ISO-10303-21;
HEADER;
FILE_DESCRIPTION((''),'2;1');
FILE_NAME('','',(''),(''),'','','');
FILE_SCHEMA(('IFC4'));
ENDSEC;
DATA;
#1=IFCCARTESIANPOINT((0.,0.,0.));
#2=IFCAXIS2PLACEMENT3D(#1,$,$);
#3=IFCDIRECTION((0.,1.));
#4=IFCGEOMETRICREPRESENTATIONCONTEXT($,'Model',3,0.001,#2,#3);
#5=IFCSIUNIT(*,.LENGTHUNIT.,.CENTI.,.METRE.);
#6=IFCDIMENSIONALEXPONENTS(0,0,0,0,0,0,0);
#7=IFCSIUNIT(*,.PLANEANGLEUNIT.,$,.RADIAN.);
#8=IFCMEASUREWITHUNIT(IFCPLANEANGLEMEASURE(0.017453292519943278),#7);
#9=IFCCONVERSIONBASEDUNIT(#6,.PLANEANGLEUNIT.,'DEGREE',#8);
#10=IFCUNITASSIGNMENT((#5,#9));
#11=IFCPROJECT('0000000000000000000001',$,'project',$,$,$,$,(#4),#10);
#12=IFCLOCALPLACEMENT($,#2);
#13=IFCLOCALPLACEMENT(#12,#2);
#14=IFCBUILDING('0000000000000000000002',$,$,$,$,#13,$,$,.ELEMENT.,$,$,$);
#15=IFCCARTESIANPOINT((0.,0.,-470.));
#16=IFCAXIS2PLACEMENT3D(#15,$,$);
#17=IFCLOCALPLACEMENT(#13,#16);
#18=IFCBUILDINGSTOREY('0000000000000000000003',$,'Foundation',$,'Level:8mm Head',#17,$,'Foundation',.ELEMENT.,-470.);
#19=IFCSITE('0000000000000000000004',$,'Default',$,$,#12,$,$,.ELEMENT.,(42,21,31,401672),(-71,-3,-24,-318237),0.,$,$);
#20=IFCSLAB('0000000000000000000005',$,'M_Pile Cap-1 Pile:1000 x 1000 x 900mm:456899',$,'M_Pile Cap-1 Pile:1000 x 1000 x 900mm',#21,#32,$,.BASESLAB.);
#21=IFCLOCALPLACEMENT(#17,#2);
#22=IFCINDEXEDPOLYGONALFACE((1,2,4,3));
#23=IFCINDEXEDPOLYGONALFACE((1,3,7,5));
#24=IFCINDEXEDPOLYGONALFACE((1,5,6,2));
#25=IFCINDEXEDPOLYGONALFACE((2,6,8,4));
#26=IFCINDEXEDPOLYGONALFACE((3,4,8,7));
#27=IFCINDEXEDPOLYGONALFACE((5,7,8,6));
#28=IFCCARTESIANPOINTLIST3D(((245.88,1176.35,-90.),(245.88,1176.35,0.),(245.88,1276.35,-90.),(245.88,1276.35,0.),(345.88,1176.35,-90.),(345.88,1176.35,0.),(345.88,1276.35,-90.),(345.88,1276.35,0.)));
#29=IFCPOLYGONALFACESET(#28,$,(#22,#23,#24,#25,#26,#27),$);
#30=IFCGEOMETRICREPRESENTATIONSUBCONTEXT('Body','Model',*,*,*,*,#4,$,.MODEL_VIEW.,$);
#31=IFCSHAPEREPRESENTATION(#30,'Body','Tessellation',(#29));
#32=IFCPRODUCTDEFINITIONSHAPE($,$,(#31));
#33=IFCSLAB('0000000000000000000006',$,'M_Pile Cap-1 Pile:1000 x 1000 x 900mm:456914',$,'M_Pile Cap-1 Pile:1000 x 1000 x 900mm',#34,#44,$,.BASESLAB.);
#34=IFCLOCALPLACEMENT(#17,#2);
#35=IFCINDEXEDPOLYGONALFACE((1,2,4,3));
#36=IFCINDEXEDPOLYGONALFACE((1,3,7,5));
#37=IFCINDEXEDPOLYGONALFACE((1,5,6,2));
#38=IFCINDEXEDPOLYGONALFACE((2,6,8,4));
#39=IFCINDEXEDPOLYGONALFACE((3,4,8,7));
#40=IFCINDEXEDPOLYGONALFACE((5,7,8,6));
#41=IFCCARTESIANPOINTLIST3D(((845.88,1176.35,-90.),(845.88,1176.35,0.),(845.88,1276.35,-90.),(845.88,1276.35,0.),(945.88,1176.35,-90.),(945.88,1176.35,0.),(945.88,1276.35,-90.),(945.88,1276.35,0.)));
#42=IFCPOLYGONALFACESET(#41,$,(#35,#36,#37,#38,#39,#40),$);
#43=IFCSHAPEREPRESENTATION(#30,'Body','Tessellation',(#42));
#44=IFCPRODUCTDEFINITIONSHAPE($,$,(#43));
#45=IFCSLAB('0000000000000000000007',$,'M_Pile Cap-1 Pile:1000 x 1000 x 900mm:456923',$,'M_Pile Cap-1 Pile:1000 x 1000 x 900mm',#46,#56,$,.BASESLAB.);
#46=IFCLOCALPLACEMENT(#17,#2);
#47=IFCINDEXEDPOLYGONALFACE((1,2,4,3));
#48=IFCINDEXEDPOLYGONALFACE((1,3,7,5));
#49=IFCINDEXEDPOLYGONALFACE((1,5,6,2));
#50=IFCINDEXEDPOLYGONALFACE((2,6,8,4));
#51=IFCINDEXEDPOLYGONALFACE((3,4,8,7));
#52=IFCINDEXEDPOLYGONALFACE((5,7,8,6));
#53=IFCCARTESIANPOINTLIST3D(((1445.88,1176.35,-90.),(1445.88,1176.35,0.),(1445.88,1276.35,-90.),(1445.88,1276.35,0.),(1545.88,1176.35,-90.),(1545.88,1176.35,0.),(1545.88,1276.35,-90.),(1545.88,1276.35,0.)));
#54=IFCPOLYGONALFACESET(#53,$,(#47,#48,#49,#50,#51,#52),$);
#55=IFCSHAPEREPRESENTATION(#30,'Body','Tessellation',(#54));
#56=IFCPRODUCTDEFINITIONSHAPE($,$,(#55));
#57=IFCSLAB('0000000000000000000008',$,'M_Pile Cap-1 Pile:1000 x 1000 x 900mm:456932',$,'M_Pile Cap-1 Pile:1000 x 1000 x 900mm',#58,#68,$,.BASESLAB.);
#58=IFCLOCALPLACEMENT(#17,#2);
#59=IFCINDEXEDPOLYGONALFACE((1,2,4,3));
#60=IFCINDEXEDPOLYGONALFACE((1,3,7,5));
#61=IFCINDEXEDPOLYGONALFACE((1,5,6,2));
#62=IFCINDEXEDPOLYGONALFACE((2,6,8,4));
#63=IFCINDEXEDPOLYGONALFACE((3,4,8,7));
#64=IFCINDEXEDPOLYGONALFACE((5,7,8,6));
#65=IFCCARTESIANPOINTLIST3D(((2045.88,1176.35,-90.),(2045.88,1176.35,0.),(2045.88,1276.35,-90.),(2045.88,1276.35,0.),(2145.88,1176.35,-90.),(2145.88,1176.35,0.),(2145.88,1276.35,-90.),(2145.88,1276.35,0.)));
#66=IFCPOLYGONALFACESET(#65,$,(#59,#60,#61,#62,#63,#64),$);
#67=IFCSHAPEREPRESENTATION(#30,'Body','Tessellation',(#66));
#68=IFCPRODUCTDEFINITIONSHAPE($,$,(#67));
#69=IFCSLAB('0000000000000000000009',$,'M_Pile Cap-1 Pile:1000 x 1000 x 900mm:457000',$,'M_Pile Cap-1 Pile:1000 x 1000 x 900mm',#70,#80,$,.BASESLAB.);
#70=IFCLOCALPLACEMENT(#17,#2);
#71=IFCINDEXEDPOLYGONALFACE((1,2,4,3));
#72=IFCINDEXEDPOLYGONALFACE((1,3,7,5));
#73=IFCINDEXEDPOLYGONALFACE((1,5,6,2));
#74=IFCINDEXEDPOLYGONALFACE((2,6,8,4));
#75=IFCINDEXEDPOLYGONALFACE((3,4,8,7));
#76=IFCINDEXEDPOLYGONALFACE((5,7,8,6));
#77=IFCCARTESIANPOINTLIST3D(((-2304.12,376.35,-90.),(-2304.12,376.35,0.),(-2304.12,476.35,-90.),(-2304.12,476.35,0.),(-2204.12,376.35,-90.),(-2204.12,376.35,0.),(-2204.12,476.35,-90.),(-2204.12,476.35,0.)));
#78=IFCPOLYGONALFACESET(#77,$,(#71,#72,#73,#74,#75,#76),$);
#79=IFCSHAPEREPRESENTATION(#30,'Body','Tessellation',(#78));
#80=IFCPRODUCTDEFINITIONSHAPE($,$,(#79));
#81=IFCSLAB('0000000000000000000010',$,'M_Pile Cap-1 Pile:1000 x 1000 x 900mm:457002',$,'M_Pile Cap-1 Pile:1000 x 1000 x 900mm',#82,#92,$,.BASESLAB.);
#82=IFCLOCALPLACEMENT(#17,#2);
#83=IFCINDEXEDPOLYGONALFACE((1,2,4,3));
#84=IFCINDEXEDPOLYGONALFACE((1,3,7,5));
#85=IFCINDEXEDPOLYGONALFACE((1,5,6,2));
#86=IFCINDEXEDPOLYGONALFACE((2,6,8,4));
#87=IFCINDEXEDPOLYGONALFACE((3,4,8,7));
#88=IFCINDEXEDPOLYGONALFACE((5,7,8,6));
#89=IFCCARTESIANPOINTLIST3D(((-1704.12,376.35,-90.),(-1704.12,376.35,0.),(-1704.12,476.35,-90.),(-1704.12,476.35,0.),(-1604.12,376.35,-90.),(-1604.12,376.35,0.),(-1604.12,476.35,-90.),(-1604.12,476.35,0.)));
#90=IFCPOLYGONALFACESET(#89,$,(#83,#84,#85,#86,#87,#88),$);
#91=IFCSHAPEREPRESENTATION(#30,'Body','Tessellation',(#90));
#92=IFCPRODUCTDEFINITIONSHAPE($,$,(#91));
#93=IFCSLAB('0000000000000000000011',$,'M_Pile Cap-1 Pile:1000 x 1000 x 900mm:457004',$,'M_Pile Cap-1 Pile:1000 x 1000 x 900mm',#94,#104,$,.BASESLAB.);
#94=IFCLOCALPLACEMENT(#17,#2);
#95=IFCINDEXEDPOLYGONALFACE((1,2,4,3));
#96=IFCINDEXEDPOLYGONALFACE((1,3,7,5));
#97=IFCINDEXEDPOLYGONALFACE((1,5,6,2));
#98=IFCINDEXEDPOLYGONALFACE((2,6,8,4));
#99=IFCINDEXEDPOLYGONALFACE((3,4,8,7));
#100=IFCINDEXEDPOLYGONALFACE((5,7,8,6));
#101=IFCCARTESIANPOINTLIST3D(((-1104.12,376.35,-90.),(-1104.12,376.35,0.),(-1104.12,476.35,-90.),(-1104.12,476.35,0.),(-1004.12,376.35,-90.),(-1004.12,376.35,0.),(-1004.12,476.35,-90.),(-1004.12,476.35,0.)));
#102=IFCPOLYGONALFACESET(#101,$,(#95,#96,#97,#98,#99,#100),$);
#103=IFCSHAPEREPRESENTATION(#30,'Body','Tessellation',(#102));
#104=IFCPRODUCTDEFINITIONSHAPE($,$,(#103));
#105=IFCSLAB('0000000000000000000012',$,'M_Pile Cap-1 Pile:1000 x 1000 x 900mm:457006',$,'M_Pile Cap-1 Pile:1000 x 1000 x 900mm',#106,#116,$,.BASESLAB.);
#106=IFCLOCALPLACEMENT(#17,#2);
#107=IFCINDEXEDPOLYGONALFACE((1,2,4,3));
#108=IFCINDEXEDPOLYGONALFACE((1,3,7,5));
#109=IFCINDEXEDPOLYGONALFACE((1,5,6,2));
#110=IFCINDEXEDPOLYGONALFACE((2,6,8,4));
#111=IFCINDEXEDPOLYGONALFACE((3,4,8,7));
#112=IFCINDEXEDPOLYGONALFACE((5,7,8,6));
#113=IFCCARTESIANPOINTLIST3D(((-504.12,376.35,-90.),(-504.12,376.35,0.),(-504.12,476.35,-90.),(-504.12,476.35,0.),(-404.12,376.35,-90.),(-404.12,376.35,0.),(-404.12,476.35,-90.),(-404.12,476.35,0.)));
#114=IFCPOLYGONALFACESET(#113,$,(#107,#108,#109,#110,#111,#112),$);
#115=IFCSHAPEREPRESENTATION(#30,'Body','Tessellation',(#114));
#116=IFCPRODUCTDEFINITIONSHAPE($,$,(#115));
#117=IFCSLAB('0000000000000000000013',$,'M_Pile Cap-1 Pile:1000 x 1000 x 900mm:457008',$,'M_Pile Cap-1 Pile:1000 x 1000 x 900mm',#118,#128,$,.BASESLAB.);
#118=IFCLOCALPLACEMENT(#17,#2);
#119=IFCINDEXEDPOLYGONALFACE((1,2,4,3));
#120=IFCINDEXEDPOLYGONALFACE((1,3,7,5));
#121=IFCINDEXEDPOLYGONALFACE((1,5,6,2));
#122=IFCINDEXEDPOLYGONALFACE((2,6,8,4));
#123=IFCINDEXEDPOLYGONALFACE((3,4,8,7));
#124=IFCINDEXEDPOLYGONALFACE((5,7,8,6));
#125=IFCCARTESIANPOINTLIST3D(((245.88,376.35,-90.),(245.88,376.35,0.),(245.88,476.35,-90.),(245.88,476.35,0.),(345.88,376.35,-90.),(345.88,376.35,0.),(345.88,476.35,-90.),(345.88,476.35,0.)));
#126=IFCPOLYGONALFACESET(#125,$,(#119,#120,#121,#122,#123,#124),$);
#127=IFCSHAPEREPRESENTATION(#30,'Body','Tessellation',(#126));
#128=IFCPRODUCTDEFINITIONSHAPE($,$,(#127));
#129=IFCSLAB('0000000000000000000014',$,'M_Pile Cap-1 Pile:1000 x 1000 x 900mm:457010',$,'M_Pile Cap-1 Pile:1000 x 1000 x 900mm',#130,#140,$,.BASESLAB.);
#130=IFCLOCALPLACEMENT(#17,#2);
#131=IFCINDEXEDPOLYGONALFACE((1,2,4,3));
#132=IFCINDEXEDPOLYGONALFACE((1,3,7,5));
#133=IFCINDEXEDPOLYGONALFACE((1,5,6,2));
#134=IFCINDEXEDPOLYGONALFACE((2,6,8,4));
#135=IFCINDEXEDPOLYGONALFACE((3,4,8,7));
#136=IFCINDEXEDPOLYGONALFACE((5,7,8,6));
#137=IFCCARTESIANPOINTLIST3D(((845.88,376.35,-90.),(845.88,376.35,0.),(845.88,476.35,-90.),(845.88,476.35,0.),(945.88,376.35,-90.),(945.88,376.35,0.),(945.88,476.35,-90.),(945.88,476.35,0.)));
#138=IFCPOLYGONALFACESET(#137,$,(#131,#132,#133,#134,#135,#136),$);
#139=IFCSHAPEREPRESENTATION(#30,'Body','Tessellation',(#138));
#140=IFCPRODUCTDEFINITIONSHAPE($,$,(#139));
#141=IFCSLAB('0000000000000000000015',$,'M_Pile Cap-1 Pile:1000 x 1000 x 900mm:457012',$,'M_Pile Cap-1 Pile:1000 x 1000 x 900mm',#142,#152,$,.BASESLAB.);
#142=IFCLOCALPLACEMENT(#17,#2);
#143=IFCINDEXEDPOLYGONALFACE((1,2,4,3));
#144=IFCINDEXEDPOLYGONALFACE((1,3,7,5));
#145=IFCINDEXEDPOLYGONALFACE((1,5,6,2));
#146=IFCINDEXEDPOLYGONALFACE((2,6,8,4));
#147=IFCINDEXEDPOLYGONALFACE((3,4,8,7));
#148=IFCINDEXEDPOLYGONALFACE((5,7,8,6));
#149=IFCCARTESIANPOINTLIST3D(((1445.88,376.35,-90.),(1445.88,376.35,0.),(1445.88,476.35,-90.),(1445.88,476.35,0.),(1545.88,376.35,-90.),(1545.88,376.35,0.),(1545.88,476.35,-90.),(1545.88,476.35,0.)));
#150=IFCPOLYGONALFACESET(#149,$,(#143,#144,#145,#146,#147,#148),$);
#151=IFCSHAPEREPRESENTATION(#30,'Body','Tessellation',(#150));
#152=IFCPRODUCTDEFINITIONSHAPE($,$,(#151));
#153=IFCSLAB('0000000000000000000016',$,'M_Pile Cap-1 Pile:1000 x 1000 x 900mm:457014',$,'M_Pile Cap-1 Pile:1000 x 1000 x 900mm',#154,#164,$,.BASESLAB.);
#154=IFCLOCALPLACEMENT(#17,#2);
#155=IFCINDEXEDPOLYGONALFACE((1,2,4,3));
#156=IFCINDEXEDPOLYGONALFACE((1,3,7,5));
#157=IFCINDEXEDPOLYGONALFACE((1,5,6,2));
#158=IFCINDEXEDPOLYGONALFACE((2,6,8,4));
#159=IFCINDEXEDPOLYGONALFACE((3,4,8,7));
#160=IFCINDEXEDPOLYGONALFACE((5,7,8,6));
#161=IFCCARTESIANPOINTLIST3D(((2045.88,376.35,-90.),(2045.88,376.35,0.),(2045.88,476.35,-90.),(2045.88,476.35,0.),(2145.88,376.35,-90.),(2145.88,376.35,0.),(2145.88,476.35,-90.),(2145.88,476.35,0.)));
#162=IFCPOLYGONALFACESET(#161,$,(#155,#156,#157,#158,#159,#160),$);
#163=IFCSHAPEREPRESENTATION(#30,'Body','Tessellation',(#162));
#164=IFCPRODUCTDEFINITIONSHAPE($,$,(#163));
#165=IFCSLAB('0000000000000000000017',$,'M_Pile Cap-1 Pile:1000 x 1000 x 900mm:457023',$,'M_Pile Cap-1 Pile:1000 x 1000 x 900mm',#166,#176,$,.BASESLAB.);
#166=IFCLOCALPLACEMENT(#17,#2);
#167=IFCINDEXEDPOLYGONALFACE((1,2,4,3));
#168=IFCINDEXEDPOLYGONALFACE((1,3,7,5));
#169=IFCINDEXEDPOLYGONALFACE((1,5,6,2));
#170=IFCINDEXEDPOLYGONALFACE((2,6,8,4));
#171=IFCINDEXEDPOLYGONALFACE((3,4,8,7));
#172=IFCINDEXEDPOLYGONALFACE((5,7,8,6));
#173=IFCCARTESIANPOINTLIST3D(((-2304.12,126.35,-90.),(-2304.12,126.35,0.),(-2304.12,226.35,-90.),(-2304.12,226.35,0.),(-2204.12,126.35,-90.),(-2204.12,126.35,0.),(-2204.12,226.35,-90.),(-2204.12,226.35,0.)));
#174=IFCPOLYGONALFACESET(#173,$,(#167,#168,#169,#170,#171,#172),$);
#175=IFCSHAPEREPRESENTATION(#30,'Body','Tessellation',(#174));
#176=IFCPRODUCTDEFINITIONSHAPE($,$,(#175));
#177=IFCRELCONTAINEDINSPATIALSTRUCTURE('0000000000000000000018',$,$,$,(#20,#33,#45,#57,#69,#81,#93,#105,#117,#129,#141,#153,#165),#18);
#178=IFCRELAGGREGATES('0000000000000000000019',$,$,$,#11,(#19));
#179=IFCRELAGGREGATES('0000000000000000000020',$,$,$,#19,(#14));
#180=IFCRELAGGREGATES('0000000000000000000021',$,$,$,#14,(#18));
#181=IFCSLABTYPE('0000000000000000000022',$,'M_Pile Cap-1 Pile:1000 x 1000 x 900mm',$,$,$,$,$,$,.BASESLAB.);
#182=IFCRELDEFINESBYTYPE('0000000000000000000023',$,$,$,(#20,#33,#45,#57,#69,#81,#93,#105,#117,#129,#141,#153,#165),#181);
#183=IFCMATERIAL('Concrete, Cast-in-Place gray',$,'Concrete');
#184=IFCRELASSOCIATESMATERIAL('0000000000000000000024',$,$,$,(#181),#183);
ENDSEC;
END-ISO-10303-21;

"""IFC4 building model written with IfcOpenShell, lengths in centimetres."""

from ifc_helpers import new_model, entity, si_unit, converted_unit, direction, frame, origin, place, context, subcontext, project, spatial, indexed_curve, outline, extrude, material, type_object, element, save


model = new_model("IFC4")

# Units and contexts
model_context = context("Model", 3, precision=0.001, world=origin(), true_north=direction((0.0, 1.0)))
body_context = subcontext(model_context, "Body", "Model", "MODEL_VIEW")
ifc_project = project(units=[si_unit("LENGTHUNIT", "METRE", prefix="CENTI"), converted_unit("PLANEANGLEUNIT", "DEGREE", entity("IfcPlaneAngleMeasure", 0.017453292519943278), si_unit("PLANEANGLEUNIT", "RADIAN"), dimensions=[0, 0, 0, 0, 0, 0, 0])], contexts=[model_context])

# Site, building, storey
site_placement = place(None, origin())
site = spatial("IfcSite", under=ifc_project, at=site_placement, Name="Default", CompositionType="ELEMENT", RefLatitude=(42, 21, 31, 401672), RefLongitude=(-71, -3, -24, -318237), RefElevation=0.0)
building_placement = place(site_placement, origin())
building = spatial("IfcBuilding", under=site, at=building_placement, CompositionType="ELEMENT")
storey_placement = place(building_placement, frame((0.0, 0.0, -470.0)))
storey = spatial("IfcBuildingStorey", under=building, at=storey_placement, Name="Foundation", ObjectType="Level:8mm Head", LongName="Foundation", CompositionType="ELEMENT", Elevation=-470.0)

# Slabs
ifc_material_1 = material(Name="Concrete, Cast-in-Place gray", Category="Concrete")
slab_type_1 = type_object("IfcSlabType", Name="M_Pile Cap-1 Pile:1000 x 1000 x 900mm", PredefinedType="BASESLAB", material=ifc_material_1)
slab_1_placement = place(storey_placement, origin())
element("IfcSlab", 1, at=slab_1_placement, inside=storey, type_object=slab_type_1, Name="M_Pile Cap-1 Pile:1000 x 1000 x 900mm:456899", ObjectType="M_Pile Cap-1 Pile:1000 x 1000 x 900mm", PredefinedType="BASESLAB", context=body_context, shape_type="SweptSolid", body=[
    extrude(outline(indexed_curve([(-50.0, -50.0), (50.0, -50.0), (50.0, 50.0), (-50.0, 50.0), (-50.0, -50.0)], self_intersect=False)), frame((295.88, 1226.35, -90.0), z_axis=(0.0, 0.0, 1.0), x_axis=(-1.0, 0.0, 0.0)), (0.0, 0.0, 1.0), 90.0),
])
slab_2_placement = place(storey_placement, origin())
element("IfcSlab", 2, at=slab_2_placement, inside=storey, type_object=slab_type_1, Name="M_Pile Cap-1 Pile:1000 x 1000 x 900mm:456914", ObjectType="M_Pile Cap-1 Pile:1000 x 1000 x 900mm", PredefinedType="BASESLAB", context=body_context, shape_type="SweptSolid", body=[
    extrude(outline(indexed_curve([(-50.0, -50.0), (50.0, -50.0), (50.0, 50.0), (-50.0, 50.0), (-50.0, -50.0)], self_intersect=False)), frame((895.88, 1226.35, -90.0), z_axis=(0.0, 0.0, 1.0), x_axis=(-1.0, 0.0, 0.0)), (0.0, 0.0, 1.0), 90.0),
])
slab_3_placement = place(storey_placement, origin())
element("IfcSlab", 3, at=slab_3_placement, inside=storey, type_object=slab_type_1, Name="M_Pile Cap-1 Pile:1000 x 1000 x 900mm:456923", ObjectType="M_Pile Cap-1 Pile:1000 x 1000 x 900mm", PredefinedType="BASESLAB", context=body_context, shape_type="SweptSolid", body=[
    extrude(outline(indexed_curve([(-50.0, -50.0), (50.0, -50.0), (50.0, 50.0), (-50.0, 50.0), (-50.0, -50.0)], self_intersect=False)), frame((1495.88, 1226.35, -90.0), z_axis=(0.0, 0.0, 1.0), x_axis=(-1.0, 0.0, 0.0)), (0.0, 0.0, 1.0), 90.0),
])
slab_4_placement = place(storey_placement, origin())
element("IfcSlab", 4, at=slab_4_placement, inside=storey, type_object=slab_type_1, Name="M_Pile Cap-1 Pile:1000 x 1000 x 900mm:456932", ObjectType="M_Pile Cap-1 Pile:1000 x 1000 x 900mm", PredefinedType="BASESLAB", context=body_context, shape_type="SweptSolid", body=[
    extrude(outline(indexed_curve([(-50.0, -50.0), (50.0, -50.0), (50.0, 50.0), (-50.0, 50.0), (-50.0, -50.0)], self_intersect=False)), frame((2095.88, 1226.35, -90.0), z_axis=(0.0, 0.0, 1.0), x_axis=(-1.0, 0.0, 0.0)), (0.0, 0.0, 1.0), 90.0),
])
slab_5_placement = place(storey_placement, origin())
element("IfcSlab", 5, at=slab_5_placement, inside=storey, type_object=slab_type_1, Name="M_Pile Cap-1 Pile:1000 x 1000 x 900mm:457000", ObjectType="M_Pile Cap-1 Pile:1000 x 1000 x 900mm", PredefinedType="BASESLAB", context=body_context, shape_type="SweptSolid", body=[
    extrude(outline(indexed_curve([(-50.0, -50.0), (50.0, -50.0), (50.0, 50.0), (-50.0, 50.0), (-50.0, -50.0)], self_intersect=False)), frame((-2254.12, 426.35, -90.0), z_axis=(0.0, 0.0, 1.0), x_axis=(-1.0, 0.0, 0.0)), (0.0, 0.0, 1.0), 90.0),
])
slab_6_placement = place(storey_placement, origin())
element("IfcSlab", 6, at=slab_6_placement, inside=storey, type_object=slab_type_1, Name="M_Pile Cap-1 Pile:1000 x 1000 x 900mm:457002", ObjectType="M_Pile Cap-1 Pile:1000 x 1000 x 900mm", PredefinedType="BASESLAB", context=body_context, shape_type="SweptSolid", body=[
    extrude(outline(indexed_curve([(-50.0, -50.0), (50.0, -50.0), (50.0, 50.0), (-50.0, 50.0), (-50.0, -50.0)], self_intersect=False)), frame((-1654.12, 426.35, -90.0), z_axis=(0.0, 0.0, 1.0), x_axis=(-1.0, 0.0, 0.0)), (0.0, 0.0, 1.0), 90.0),
])
slab_7_placement = place(storey_placement, origin())
element("IfcSlab", 7, at=slab_7_placement, inside=storey, type_object=slab_type_1, Name="M_Pile Cap-1 Pile:1000 x 1000 x 900mm:457004", ObjectType="M_Pile Cap-1 Pile:1000 x 1000 x 900mm", PredefinedType="BASESLAB", context=body_context, shape_type="SweptSolid", body=[
    extrude(outline(indexed_curve([(-50.0, -50.0), (50.0, -50.0), (50.0, 50.0), (-50.0, 50.0), (-50.0, -50.0)], self_intersect=False)), frame((-1054.12, 426.35, -90.0), z_axis=(0.0, 0.0, 1.0), x_axis=(-1.0, 0.0, 0.0)), (0.0, 0.0, 1.0), 90.0),
])
slab_8_placement = place(storey_placement, origin())
element("IfcSlab", 8, at=slab_8_placement, inside=storey, type_object=slab_type_1, Name="M_Pile Cap-1 Pile:1000 x 1000 x 900mm:457006", ObjectType="M_Pile Cap-1 Pile:1000 x 1000 x 900mm", PredefinedType="BASESLAB", context=body_context, shape_type="SweptSolid", body=[
    extrude(outline(indexed_curve([(-50.0, -50.0), (50.0, -50.0), (50.0, 50.0), (-50.0, 50.0), (-50.0, -50.0)], self_intersect=False)), frame((-454.12, 426.35, -90.0), z_axis=(0.0, 0.0, 1.0), x_axis=(-1.0, 0.0, 0.0)), (0.0, 0.0, 1.0), 90.0),
])
slab_9_placement = place(storey_placement, origin())
element("IfcSlab", 9, at=slab_9_placement, inside=storey, type_object=slab_type_1, Name="M_Pile Cap-1 Pile:1000 x 1000 x 900mm:457008", ObjectType="M_Pile Cap-1 Pile:1000 x 1000 x 900mm", PredefinedType="BASESLAB", context=body_context, shape_type="SweptSolid", body=[
    extrude(outline(indexed_curve([(-50.0, -50.0), (50.0, -50.0), (50.0, 50.0), (-50.0, 50.0), (-50.0, -50.0)], self_intersect=False)), frame((295.88, 426.35, -90.0), z_axis=(0.0, 0.0, 1.0), x_axis=(-1.0, 0.0, 0.0)), (0.0, 0.0, 1.0), 90.0),
])
slab_10_placement = place(storey_placement, origin())
element("IfcSlab", 10, at=slab_10_placement, inside=storey, type_object=slab_type_1, Name="M_Pile Cap-1 Pile:1000 x 1000 x 900mm:457010", ObjectType="M_Pile Cap-1 Pile:1000 x 1000 x 900mm", PredefinedType="BASESLAB", context=body_context, shape_type="SweptSolid", body=[
    extrude(outline(indexed_curve([(-50.0, -50.0), (50.0, -50.0), (50.0, 50.0), (-50.0, 50.0), (-50.0, -50.0)], self_intersect=False)), frame((895.88, 426.35, -90.0), z_axis=(0.0, 0.0, 1.0), x_axis=(-1.0, 0.0, 0.0)), (0.0, 0.0, 1.0), 90.0),
])
slab_11_placement = place(storey_placement, origin())
element("IfcSlab", 11, at=slab_11_placement, inside=storey, type_object=slab_type_1, Name="M_Pile Cap-1 Pile:1000 x 1000 x 900mm:457012", ObjectType="M_Pile Cap-1 Pile:1000 x 1000 x 900mm", PredefinedType="BASESLAB", context=body_context, shape_type="SweptSolid", body=[
    extrude(outline(indexed_curve([(-50.0, -50.0), (50.0, -50.0), (50.0, 50.0), (-50.0, 50.0), (-50.0, -50.0)], self_intersect=False)), frame((1495.88, 426.35, -90.0), z_axis=(0.0, 0.0, 1.0), x_axis=(-1.0, 0.0, 0.0)), (0.0, 0.0, 1.0), 90.0),
])
slab_12_placement = place(storey_placement, origin())
element("IfcSlab", 12, at=slab_12_placement, inside=storey, type_object=slab_type_1, Name="M_Pile Cap-1 Pile:1000 x 1000 x 900mm:457014", ObjectType="M_Pile Cap-1 Pile:1000 x 1000 x 900mm", PredefinedType="BASESLAB", context=body_context, shape_type="SweptSolid", body=[
    extrude(outline(indexed_curve([(-50.0, -50.0), (50.0, -50.0), (50.0, 50.0), (-50.0, 50.0), (-50.0, -50.0)], self_intersect=False)), frame((2095.88, 426.35, -90.0), z_axis=(0.0, 0.0, 1.0), x_axis=(-1.0, 0.0, 0.0)), (0.0, 0.0, 1.0), 90.0),
])
slab_13_placement = place(storey_placement, origin())
element("IfcSlab", 13, at=slab_13_placement, inside=storey, type_object=slab_type_1, Name="M_Pile Cap-1 Pile:1000 x 1000 x 900mm:457023", ObjectType="M_Pile Cap-1 Pile:1000 x 1000 x 900mm", PredefinedType="BASESLAB", context=body_context, shape_type="SweptSolid", body=[
    extrude(outline(indexed_curve([(-50.0, -50.0), (50.0, -50.0), (50.0, 50.0), (-50.0, 50.0), (-50.0, -50.0)], self_intersect=False)), frame((-2254.12, 176.35, -90.0), z_axis=(0.0, 0.0, 1.0), x_axis=(-1.0, 0.0, 0.0)), (0.0, 0.0, 1.0), 90.0),
])

save(model, "model.ifc")
